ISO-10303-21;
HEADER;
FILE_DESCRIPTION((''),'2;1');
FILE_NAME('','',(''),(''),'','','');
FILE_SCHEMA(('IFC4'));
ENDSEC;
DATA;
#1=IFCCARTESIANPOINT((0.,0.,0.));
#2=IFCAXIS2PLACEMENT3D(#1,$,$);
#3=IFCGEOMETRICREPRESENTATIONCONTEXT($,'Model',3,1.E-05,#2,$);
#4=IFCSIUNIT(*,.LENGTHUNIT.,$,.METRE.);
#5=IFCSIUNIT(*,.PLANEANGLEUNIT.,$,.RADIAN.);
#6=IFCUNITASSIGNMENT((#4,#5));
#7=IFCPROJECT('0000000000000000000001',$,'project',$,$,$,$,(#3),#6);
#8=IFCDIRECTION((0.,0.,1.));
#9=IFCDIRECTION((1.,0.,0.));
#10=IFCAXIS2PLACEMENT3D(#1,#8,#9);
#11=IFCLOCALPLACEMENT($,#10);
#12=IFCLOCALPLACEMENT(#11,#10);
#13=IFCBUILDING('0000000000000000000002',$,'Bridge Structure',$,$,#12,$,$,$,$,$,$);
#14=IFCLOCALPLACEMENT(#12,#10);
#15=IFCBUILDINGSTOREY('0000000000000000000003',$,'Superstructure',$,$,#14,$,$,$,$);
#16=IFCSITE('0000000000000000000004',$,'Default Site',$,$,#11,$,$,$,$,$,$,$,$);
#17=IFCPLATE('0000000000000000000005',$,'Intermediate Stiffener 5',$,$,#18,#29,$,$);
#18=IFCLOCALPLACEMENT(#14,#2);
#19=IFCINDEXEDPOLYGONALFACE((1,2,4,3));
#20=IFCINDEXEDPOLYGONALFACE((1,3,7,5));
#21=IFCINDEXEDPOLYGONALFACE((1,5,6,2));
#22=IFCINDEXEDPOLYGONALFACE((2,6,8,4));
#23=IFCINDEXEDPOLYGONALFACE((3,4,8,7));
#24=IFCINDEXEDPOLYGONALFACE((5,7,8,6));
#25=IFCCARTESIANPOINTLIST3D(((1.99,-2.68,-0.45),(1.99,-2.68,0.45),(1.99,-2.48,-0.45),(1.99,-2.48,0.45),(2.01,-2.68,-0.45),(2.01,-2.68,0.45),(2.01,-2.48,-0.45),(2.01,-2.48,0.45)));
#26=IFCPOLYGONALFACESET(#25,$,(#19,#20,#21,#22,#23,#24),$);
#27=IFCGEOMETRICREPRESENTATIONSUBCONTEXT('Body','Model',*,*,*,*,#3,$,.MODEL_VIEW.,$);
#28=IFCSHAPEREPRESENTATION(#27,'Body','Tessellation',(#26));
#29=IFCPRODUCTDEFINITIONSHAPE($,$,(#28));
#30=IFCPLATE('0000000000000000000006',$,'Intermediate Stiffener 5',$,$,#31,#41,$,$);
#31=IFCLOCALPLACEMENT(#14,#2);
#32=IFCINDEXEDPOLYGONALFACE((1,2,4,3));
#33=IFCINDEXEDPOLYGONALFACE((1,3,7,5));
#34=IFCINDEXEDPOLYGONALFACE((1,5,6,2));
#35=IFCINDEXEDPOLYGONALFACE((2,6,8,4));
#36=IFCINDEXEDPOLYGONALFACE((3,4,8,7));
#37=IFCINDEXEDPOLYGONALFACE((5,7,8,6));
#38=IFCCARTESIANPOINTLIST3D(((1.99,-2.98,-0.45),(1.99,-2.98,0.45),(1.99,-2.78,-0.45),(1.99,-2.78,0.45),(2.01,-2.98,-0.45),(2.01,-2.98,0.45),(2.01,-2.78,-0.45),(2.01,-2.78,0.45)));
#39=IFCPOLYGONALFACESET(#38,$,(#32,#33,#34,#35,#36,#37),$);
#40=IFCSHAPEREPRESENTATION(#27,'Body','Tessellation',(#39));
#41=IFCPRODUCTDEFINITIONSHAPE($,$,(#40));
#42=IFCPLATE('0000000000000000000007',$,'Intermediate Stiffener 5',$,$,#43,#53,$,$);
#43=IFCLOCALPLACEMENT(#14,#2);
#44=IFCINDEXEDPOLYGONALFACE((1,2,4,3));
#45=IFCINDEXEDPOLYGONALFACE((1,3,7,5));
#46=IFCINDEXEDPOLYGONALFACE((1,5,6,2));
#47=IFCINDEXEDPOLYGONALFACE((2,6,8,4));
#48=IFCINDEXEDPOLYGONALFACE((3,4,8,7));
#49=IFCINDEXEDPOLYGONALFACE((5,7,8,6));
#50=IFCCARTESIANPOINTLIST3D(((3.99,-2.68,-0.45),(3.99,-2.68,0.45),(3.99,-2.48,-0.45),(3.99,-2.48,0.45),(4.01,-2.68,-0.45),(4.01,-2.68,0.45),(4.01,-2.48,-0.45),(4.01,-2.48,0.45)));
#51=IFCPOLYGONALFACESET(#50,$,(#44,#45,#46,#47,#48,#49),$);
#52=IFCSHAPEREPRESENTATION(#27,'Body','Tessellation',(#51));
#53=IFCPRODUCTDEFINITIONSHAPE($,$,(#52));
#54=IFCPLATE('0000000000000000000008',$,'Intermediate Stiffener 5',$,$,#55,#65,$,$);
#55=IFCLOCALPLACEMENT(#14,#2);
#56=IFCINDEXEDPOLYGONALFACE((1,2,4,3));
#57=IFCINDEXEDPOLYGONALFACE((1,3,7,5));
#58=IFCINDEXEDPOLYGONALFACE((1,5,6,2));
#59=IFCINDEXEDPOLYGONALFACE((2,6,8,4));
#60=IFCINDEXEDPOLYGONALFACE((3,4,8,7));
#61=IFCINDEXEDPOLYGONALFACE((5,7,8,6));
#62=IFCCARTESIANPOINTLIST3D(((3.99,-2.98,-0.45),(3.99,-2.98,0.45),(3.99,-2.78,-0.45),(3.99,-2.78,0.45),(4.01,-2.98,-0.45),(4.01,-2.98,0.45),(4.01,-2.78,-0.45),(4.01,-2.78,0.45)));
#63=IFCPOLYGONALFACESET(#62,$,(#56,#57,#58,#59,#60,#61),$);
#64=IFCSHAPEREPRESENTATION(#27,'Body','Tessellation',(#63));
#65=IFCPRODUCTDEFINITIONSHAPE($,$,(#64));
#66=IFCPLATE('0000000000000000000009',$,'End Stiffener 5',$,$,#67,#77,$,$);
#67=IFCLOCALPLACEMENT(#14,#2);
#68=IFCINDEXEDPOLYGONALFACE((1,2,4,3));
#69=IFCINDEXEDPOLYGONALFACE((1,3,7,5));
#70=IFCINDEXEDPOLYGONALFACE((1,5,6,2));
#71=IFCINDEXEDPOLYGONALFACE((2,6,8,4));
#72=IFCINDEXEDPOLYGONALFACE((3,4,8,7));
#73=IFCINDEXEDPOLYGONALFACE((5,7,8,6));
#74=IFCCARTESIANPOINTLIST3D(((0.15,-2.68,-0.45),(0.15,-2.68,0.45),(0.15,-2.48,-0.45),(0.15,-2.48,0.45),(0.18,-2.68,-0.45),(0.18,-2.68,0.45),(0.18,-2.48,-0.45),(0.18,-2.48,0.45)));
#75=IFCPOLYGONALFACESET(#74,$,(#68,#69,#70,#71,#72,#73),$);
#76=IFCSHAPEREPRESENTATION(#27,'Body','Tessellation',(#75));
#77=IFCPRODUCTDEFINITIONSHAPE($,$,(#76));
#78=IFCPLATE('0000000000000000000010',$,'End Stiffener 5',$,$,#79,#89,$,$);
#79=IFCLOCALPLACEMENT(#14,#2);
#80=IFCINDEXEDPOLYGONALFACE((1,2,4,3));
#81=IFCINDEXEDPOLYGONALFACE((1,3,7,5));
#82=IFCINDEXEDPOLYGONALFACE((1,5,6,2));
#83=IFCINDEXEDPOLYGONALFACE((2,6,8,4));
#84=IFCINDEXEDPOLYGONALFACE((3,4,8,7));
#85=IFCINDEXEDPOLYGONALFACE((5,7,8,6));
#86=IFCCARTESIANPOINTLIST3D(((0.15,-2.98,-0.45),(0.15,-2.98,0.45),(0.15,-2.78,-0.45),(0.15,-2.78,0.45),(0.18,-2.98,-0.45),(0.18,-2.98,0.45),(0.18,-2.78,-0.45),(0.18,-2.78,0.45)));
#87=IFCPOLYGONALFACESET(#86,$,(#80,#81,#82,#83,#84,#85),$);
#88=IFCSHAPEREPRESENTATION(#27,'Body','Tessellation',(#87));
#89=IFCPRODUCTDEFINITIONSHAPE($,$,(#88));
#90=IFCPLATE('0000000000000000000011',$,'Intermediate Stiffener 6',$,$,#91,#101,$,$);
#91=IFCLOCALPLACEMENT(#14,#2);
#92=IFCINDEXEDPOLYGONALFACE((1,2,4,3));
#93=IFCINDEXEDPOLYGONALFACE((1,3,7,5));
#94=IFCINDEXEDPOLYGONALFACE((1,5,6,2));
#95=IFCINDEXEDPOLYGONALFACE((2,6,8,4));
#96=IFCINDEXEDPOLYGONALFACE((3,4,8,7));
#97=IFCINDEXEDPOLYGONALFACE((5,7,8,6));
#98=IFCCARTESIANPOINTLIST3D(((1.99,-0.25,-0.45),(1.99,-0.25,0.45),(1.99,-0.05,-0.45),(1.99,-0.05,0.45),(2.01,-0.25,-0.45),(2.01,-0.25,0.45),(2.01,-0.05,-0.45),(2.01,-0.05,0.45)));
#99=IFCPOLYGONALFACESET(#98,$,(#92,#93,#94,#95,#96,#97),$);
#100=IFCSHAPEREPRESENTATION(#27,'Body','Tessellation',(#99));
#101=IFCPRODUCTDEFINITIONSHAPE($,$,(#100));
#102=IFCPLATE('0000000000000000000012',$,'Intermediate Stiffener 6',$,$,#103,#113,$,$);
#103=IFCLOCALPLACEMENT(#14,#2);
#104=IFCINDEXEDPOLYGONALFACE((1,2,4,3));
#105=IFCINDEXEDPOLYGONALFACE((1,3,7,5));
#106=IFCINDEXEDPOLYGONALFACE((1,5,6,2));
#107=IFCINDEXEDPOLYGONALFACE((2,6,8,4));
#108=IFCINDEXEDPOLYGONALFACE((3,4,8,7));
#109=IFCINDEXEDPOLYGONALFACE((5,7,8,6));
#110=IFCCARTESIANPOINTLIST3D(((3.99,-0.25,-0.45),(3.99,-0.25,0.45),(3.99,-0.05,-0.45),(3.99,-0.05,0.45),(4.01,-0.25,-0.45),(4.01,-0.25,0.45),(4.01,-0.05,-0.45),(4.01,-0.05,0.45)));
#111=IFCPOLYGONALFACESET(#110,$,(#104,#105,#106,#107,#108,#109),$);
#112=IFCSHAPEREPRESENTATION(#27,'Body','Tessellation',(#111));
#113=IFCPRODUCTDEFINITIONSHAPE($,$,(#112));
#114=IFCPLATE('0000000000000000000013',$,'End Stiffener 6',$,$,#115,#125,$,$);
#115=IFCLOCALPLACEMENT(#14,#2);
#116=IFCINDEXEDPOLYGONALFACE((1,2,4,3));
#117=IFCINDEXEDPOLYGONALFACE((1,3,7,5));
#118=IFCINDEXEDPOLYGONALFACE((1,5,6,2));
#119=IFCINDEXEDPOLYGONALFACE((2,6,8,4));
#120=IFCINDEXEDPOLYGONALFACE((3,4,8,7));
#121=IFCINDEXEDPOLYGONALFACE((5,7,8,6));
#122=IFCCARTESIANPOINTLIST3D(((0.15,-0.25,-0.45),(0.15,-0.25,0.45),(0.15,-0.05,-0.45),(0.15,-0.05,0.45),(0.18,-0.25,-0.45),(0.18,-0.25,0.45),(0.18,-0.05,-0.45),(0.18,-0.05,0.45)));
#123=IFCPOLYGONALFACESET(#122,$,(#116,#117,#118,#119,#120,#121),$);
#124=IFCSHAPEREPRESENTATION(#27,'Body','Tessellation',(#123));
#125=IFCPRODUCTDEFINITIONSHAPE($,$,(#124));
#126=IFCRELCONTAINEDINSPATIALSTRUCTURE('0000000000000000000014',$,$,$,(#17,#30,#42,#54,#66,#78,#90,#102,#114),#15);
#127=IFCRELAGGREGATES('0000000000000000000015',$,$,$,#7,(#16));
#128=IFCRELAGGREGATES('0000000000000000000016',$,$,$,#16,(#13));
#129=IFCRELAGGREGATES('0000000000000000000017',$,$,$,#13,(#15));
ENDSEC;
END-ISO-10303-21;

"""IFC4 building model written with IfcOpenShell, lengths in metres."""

from ifc_helpers import new_model, si_unit, frame, origin, origin_with_axes, origin_2d_with_axis, place, context, subcontext, project, spatial, rectangle, extrude, element, save


model = new_model("IFC4")

# Units and contexts
model_context = context("Model", 3, precision=1e-05, world=origin())
body_context = subcontext(model_context, "Body", "Model", "MODEL_VIEW")
ifc_project = project(units=[si_unit("LENGTHUNIT", "METRE"), si_unit("PLANEANGLEUNIT", "RADIAN")], contexts=[model_context])

# Site, building, storey
site_placement = place(None, origin_with_axes())
site = spatial("IfcSite", under=ifc_project, at=site_placement, Name="Default Site")
building_placement = place(site_placement, origin_with_axes())
building = spatial("IfcBuilding", under=site, at=building_placement, Name="Bridge Structure")
storey_placement = place(building_placement, origin_with_axes())
storey = spatial("IfcBuildingStorey", under=building, at=storey_placement, Name="Superstructure")

# Plates
for number, where, z_axis, x_axis, name in (
    (1, (2.0, -2.58, -0.45), (0.0, 0.0, 1.0), (1.0, 0.0, 0.0), "Intermediate Stiffener 5"),
    (2, (2.0, -2.88, -0.45), (0.0, 0.0, 1.0), (1.0, 0.0, 0.0), "Intermediate Stiffener 5"),
    (3, (4.0, -2.58, -0.45), (0.0, 0.0, 1.0), (1.0, 0.0, 0.0), "Intermediate Stiffener 5"),
    (4, (4.0, -2.88, -0.45), (0.0, 0.0, 1.0), (1.0, 0.0, 0.0), "Intermediate Stiffener 5"),
):
    element("IfcPlate", number, at=place(storey_placement, frame(where, z_axis=z_axis, x_axis=x_axis)), inside=storey, Name=name, context=body_context, shape_type="SweptSolid", body=[
        extrude(rectangle(XDim=0.02, YDim=0.2, at=origin_2d_with_axis()), origin_with_axes(), (0.0, 0.0, 1.0), 0.9),
    ])
for number, where, z_axis, x_axis, name in (
    (5, (0.165, -2.58, -0.45), (0.0, 0.0, 1.0), (1.0, 0.0, 0.0), "End Stiffener 5"),
    (6, (0.165, -2.88, -0.45), (0.0, 0.0, 1.0), (1.0, 0.0, 0.0), "End Stiffener 5"),
):
    element("IfcPlate", number, at=place(storey_placement, frame(where, z_axis=z_axis, x_axis=x_axis)), inside=storey, Name=name, context=body_context, shape_type="SweptSolid", body=[
        extrude(rectangle(XDim=0.03, YDim=0.2, at=origin_2d_with_axis()), origin_with_axes(), (0.0, 0.0, 1.0), 0.9),
    ])
for number, where, z_axis, x_axis, name in (
    (7, (2.0, -0.15, -0.45), (0.0, 0.0, 1.0), (1.0, 0.0, 0.0), "Intermediate Stiffener 6"),
    (8, (4.0, -0.15, -0.45), (0.0, 0.0, 1.0), (1.0, 0.0, 0.0), "Intermediate Stiffener 6"),
):
    element("IfcPlate", number, at=place(storey_placement, frame(where, z_axis=z_axis, x_axis=x_axis)), inside=storey, Name=name, context=body_context, shape_type="SweptSolid", body=[
        extrude(rectangle(XDim=0.02, YDim=0.2, at=origin_2d_with_axis()), origin_with_axes(), (0.0, 0.0, 1.0), 0.9),
    ])
plate_1_placement = place(storey_placement, frame((0.165, -0.15, -0.45), z_axis=(0.0, 0.0, 1.0), x_axis=(1.0, 0.0, 0.0)))
element("IfcPlate", 9, at=plate_1_placement, inside=storey, Name="End Stiffener 6", context=body_context, shape_type="SweptSolid", body=[
    extrude(rectangle(XDim=0.03, YDim=0.2, at=origin_2d_with_axis()), origin_with_axes(), (0.0, 0.0, 1.0), 0.9),
])

save(model, "model.ifc")
